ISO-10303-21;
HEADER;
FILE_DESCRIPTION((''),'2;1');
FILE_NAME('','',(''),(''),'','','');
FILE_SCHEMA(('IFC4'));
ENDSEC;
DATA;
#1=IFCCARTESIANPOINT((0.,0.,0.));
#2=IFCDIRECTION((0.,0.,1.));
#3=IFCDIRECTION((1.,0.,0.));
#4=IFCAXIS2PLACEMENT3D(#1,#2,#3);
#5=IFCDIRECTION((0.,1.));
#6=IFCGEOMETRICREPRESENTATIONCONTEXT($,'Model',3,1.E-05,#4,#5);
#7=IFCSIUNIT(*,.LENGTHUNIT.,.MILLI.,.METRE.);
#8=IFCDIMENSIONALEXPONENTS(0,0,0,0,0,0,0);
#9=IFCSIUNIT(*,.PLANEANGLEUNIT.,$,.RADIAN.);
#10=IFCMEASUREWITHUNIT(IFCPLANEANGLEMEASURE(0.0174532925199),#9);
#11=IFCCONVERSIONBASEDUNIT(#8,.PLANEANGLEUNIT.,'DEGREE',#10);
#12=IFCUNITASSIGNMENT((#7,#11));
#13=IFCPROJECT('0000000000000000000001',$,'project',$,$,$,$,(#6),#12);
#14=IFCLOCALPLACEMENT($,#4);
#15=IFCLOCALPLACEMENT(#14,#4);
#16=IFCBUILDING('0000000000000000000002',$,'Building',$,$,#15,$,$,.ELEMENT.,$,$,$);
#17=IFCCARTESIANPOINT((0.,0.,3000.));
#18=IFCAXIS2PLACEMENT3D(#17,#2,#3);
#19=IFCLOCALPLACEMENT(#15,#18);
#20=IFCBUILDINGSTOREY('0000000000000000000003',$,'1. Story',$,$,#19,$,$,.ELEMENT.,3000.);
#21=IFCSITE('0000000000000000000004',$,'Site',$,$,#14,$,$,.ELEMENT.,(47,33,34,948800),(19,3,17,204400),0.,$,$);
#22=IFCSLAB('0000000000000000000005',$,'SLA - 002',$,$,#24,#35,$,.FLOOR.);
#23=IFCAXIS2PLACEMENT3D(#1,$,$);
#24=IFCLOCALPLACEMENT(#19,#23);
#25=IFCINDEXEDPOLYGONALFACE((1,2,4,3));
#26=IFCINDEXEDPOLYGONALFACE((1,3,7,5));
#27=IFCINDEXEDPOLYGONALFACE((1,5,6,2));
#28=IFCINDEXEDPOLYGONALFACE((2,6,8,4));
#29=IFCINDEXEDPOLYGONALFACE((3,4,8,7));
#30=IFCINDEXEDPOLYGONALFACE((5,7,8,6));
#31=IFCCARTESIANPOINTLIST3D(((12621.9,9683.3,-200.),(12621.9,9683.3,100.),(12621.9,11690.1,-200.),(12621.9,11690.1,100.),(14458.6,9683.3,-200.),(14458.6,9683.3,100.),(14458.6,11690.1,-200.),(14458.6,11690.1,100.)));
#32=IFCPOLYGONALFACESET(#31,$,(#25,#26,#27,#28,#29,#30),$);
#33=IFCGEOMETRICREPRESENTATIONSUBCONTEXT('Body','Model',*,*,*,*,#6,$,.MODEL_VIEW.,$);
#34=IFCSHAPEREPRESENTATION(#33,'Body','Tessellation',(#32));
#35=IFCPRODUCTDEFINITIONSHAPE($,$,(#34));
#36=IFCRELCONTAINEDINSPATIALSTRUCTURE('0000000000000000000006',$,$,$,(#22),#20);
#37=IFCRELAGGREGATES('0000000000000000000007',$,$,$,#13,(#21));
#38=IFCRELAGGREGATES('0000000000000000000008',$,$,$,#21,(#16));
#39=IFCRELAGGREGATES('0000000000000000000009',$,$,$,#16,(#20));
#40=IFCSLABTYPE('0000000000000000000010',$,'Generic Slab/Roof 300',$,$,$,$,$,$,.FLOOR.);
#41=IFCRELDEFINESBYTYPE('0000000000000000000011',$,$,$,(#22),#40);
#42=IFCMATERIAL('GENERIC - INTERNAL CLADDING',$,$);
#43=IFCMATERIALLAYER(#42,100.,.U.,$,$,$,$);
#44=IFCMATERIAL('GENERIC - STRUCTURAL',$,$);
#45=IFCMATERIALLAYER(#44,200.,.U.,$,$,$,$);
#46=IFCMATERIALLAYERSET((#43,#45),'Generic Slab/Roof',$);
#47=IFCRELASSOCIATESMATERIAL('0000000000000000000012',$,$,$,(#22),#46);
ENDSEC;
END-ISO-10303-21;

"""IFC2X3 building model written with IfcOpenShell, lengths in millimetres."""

from ifc_helpers import new_model, entity, si_unit, converted_unit, direction, frame, origin_with_axes, place, context, subcontext, project, spatial, polyline, outline, extrude, material, layer, layer_set, layer_usage, type_object, element, save


model = new_model("IFC2X3")

# Units and contexts
model_context = context("Model", 3, precision=1e-05, world=origin_with_axes(), true_north=direction((0.0, 1.0)))
body_context = subcontext(model_context, "Body", "Model", "MODEL_VIEW")
ifc_project = project(units=[si_unit("LENGTHUNIT", "METRE", prefix="MILLI"), converted_unit("PLANEANGLEUNIT", "DEGREE", entity("IfcPlaneAngleMeasure", 0.0174532925199), si_unit("PLANEANGLEUNIT", "RADIAN"), dimensions=[0, 0, 0, 0, 0, 0, 0])], contexts=[model_context])

# Site, building, storey
site_placement = place(None, origin_with_axes())
site = spatial("IfcSite", under=ifc_project, at=site_placement, Name="Site", CompositionType="ELEMENT", RefLatitude=(47, 33, 34, 948800), RefLongitude=(19, 3, 17, 204400), RefElevation=0.0)
building_placement = place(site_placement, origin_with_axes())
building = spatial("IfcBuilding", under=site, at=building_placement, Name="Building", CompositionType="ELEMENT")
storey_placement = place(building_placement, frame((0.0, 0.0, 3000.0), z_axis=(0.0, 0.0, 1.0), x_axis=(1.0, 0.0, 0.0)))
storey = spatial("IfcBuildingStorey", under=building, at=storey_placement, Name="1. Story", CompositionType="ELEMENT", Elevation=3000.0)

# Slab
ifc_material_1 = material(Name="GENERIC - INTERNAL CLADDING")
ifc_layer_1 = layer(ifc_material_1, 100.0, ventilated="UNKNOWN")
ifc_material_2 = material(Name="GENERIC - STRUCTURAL")
ifc_layer_2 = layer(ifc_material_2, 200.0, ventilated="UNKNOWN")
ifc_layer_set = layer_set([ifc_layer_1, ifc_layer_2], Name="Generic Slab/Roof")
ifc_layer_usage = layer_usage(ifc_layer_set, "AXIS3", "NEGATIVE", 300.0)
slab_type = type_object("IfcSlabType", Name="Generic Slab/Roof 300", PredefinedType="FLOOR")
slab_placement = place(storey_placement, frame((12621.9, 9683.3, 0.0), z_axis=(0.0, 0.0, 1.0), x_axis=(1.0, 0.0, 0.0)))
element("IfcSlab", 1, at=slab_placement, inside=storey, type_object=slab_type, material=ifc_layer_usage, Name="SLA - 002", PredefinedType="FLOOR", context=body_context, shape_type="SweptSolid", body=[
    extrude(outline(polyline([(0.0, 0.0), (1836.7, 0.0), (1836.7, 2006.7), (0.0, 2006.7), (0.0, 0.0)])), frame((0.0, 0.0, -200.0), z_axis=(0.0, 0.0, 1.0), x_axis=(1.0, 0.0, 0.0)), (0.0, 0.0, 1.0), 300.0),
])

save(model, "model.ifc")
